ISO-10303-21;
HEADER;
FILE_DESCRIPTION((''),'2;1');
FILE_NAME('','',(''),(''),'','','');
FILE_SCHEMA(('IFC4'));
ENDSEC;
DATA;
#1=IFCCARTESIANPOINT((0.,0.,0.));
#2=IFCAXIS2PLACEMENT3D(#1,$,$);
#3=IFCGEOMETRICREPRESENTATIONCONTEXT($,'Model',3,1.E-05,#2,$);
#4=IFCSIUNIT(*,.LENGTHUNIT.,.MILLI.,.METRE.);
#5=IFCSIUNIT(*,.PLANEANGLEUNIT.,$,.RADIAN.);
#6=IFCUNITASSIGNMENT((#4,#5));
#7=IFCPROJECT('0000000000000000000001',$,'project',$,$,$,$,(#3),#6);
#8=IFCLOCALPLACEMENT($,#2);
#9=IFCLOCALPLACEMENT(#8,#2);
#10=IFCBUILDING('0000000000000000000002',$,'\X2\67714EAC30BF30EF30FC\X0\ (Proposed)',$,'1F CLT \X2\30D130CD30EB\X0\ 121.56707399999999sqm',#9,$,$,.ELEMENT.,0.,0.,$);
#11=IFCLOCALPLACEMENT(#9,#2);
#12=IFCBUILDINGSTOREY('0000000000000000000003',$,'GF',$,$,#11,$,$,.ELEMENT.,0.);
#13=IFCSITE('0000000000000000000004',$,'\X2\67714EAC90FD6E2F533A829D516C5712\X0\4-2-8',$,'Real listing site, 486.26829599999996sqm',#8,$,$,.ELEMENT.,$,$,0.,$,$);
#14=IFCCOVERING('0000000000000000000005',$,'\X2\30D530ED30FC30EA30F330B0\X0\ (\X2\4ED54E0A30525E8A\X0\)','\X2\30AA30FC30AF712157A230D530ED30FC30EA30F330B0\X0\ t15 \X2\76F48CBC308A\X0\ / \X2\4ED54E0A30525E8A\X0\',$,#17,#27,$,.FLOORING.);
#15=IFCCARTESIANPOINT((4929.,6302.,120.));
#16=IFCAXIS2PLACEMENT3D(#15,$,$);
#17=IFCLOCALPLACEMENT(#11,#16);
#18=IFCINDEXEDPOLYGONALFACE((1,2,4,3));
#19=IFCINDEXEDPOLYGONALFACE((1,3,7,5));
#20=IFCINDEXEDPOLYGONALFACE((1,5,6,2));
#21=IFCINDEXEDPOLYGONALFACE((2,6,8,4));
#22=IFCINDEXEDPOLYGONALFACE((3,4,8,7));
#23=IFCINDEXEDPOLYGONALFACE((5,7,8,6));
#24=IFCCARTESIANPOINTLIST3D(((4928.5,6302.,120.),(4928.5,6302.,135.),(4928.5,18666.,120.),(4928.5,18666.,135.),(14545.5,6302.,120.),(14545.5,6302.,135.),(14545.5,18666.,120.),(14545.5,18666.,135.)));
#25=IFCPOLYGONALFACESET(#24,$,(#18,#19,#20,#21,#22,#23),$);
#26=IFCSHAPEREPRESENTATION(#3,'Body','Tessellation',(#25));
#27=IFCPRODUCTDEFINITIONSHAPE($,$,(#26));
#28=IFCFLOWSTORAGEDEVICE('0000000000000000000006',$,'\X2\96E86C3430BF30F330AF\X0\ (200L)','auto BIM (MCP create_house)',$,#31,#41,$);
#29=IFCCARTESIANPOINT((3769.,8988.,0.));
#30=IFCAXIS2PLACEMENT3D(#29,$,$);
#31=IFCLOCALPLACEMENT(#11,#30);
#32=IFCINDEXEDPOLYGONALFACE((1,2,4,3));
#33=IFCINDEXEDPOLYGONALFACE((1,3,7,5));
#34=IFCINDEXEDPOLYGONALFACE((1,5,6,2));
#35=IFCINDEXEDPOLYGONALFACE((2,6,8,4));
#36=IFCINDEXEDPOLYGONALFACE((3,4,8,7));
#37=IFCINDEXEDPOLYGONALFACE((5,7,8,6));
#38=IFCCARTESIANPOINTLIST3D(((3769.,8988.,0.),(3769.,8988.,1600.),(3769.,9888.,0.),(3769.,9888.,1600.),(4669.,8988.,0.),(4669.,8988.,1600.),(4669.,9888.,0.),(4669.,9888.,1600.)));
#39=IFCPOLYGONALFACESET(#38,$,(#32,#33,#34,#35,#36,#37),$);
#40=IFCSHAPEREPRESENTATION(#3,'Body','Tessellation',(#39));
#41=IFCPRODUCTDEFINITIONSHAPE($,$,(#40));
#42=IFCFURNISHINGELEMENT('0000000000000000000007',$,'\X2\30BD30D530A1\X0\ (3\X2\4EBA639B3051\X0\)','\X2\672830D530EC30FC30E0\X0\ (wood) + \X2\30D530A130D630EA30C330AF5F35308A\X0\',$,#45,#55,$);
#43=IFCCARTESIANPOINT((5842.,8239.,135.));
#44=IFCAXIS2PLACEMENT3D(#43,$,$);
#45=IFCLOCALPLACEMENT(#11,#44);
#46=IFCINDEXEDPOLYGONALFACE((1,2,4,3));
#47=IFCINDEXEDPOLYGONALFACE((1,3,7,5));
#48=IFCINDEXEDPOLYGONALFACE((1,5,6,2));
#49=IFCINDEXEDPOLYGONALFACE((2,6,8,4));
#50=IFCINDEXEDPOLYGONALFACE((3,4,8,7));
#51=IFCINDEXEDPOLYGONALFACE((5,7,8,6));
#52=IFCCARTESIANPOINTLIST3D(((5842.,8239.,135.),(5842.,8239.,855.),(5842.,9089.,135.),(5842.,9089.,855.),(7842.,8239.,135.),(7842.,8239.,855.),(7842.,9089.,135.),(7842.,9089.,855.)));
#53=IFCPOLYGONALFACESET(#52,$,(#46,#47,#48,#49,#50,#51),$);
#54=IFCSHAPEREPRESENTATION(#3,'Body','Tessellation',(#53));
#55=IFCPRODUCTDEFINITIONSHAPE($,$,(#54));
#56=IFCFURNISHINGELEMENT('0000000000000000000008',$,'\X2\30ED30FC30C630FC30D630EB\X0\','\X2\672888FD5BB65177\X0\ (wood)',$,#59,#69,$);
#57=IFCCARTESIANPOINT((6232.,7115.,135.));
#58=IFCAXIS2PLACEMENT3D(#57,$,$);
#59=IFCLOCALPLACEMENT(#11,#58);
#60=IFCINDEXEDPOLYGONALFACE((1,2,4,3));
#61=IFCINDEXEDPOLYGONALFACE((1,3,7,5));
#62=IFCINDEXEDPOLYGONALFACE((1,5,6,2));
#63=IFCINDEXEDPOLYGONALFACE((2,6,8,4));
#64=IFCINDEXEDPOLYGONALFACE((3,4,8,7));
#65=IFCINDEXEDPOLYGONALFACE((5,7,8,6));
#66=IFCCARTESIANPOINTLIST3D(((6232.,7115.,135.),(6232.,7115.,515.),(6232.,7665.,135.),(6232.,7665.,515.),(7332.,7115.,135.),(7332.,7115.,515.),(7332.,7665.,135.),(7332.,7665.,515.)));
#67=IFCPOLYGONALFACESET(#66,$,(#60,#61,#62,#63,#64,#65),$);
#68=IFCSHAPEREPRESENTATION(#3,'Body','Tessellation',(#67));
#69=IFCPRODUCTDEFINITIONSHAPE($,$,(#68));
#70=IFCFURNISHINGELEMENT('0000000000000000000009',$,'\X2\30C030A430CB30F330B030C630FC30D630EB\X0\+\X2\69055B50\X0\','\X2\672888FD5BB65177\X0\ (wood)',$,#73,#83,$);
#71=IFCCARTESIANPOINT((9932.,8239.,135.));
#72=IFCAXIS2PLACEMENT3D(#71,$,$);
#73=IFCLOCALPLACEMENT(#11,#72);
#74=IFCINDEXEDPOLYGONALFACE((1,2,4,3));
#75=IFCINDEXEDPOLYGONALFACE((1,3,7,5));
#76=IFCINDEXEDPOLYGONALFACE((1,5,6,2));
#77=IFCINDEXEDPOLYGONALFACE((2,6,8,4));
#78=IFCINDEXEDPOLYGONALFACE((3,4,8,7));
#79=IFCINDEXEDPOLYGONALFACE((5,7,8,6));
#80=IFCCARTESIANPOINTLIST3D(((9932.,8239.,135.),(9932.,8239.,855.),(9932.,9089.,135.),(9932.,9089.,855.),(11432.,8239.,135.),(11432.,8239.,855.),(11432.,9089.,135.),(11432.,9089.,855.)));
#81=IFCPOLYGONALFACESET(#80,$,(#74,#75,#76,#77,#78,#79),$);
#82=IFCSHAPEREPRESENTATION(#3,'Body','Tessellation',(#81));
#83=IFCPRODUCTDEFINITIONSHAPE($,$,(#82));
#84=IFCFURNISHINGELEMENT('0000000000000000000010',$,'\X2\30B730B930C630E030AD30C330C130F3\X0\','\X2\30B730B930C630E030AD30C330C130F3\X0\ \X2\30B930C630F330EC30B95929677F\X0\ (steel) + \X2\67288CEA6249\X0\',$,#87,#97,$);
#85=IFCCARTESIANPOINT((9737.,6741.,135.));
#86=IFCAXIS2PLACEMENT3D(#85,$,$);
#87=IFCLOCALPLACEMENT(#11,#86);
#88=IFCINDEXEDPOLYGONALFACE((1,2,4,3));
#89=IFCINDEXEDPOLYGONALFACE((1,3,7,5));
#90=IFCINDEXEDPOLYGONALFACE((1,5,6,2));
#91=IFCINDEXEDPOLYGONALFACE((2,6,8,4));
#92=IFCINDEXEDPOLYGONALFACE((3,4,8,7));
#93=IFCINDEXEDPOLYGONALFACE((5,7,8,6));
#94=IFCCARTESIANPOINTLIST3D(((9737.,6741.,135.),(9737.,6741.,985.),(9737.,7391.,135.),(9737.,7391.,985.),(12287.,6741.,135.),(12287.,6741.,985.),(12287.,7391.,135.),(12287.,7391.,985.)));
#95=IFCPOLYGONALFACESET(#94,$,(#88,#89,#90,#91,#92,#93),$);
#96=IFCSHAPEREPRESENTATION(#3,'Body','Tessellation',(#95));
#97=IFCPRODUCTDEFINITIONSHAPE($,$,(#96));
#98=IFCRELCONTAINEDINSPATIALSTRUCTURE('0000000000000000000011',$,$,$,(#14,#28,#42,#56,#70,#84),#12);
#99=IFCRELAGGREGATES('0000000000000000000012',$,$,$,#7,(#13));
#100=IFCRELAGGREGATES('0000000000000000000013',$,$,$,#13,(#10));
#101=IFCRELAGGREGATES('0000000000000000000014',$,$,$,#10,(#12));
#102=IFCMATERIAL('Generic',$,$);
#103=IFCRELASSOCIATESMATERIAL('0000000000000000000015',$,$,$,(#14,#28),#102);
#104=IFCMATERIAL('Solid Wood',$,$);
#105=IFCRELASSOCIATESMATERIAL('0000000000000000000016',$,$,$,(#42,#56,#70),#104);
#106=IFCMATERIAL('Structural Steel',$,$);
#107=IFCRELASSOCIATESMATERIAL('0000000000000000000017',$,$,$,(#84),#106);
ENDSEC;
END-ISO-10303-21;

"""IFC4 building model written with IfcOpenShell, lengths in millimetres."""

from ifc_helpers import new_model, si_unit, frame, frame_2d, origin, place, context, project, spatial, rectangle, extrude, material, element, save


model = new_model("IFC4")

# Units and contexts
model_context = context("Model", 3, precision=1e-05, world=origin())
ifc_project = project(units=[si_unit("LENGTHUNIT", "METRE", prefix="MILLI"), si_unit("PLANEANGLEUNIT", "RADIAN")], contexts=[model_context])

# Site, building, storey
site_placement = place(None, origin())
site = spatial("IfcSite", under=ifc_project, at=site_placement, Name="東京都港区芝公園4-2-8", ObjectType="Real listing site, 486.26829599999996sqm", CompositionType="ELEMENT", RefElevation=0.0)
building_placement = place(site_placement, origin())
building = spatial("IfcBuilding", under=site, at=building_placement, Name="東京タワー (Proposed)", ObjectType="1F CLT パネル 121.56707399999999sqm", CompositionType="ELEMENT", ElevationOfRefHeight=0.0, ElevationOfTerrain=0.0)
storey_placement = place(building_placement, origin())
storey = spatial("IfcBuildingStorey", under=building, at=storey_placement, Name="GF", CompositionType="ELEMENT", Elevation=0.0)

# Shared definitions
ifc_material_1 = material(Name="Solid Wood")

# Shared definitions
ifc_material_2 = material(Name="Structural Steel")

# Covering
ifc_material_3 = material(Name="Generic")
covering_placement = place(storey_placement, frame((4929.0, 6302.0, 120.0)))
element("IfcCovering", 1, at=covering_placement, inside=storey, material=ifc_material_3, Name="フローリング (仕上げ床)", Description="オーク無垢フローリング t15 直貼り / 仕上げ床", PredefinedType="FLOORING", context=model_context, shape_type="SweptSolid", body=[
    extrude(rectangle(XDim=9617.0, YDim=12364.0, at=frame_2d((4808.0, 6182.0))), frame((4929.0, 6302.0, 120.0)), (0.0, 0.0, 1.0), 15.0),
])

# Flow storage device
flow_storage_device_placement = place(storey_placement, frame((3769.0, 8988.0, 0.0)))
element("IfcFlowStorageDevice", 2, at=flow_storage_device_placement, inside=storey, material=ifc_material_3, Name="雨水タンク (200L)", Description="auto BIM (MCP create_house)", context=model_context, shape_type="SweptSolid", body=[
    extrude(rectangle(XDim=900.0, YDim=900.0, at=frame_2d((450.0, 450.0))), frame((3769.0, 8988.0, 0.0)), (0.0, 0.0, 1.0), 1600.0),
])

# Furnishing elements
furnishing_1_placement = place(storey_placement, frame((5842.0, 8239.0, 135.0)))
element("IfcFurnishingElement", 3, at=furnishing_1_placement, inside=storey, material=ifc_material_1, Name="ソファ (3人掛け)", Description="木フレーム (wood) + ファブリック張り", context=model_context, shape_type="SweptSolid", body=[
    extrude(rectangle(XDim=2000.0, YDim=850.0, at=frame_2d((1000.0, 425.0))), frame((5842.0, 8239.0, 135.0)), (0.0, 0.0, 1.0), 720.0),
])
furnishing_2_placement = place(storey_placement, frame((6232.0, 7115.0, 135.0)))
element("IfcFurnishingElement", 4, at=furnishing_2_placement, inside=storey, material=ifc_material_1, Name="ローテーブル", Description="木製家具 (wood)", context=model_context, shape_type="SweptSolid", body=[
    extrude(rectangle(XDim=1100.0, YDim=550.0, at=frame_2d((550.0, 275.0))), frame((6232.0, 7115.0, 135.0)), (0.0, 0.0, 1.0), 380.0),
])
furnishing_3_placement = place(storey_placement, frame((9932.0, 8239.0, 135.0)))
element("IfcFurnishingElement", 5, at=furnishing_3_placement, inside=storey, material=ifc_material_1, Name="ダイニングテーブル+椅子", Description="木製家具 (wood)", context=model_context, shape_type="SweptSolid", body=[
    extrude(rectangle(XDim=1500.0, YDim=850.0, at=frame_2d((750.0, 425.0))), frame((9932.0, 8239.0, 135.0)), (0.0, 0.0, 1.0), 720.0),
])
furnishing_4_placement = place(storey_placement, frame((9737.0, 6741.0, 135.0)))
element("IfcFurnishingElement", 6, at=furnishing_4_placement, inside=storey, material=ifc_material_2, Name="システムキッチン", Description="システムキッチン ステンレス天板 (steel) + 木質扉", context=model_context, shape_type="SweptSolid", body=[
    extrude(rectangle(XDim=2550.0, YDim=650.0, at=frame_2d((1275.0, 325.0))), frame((9737.0, 6741.0, 135.0)), (0.0, 0.0, 1.0), 850.0),
])

save(model, "model.ifc")
